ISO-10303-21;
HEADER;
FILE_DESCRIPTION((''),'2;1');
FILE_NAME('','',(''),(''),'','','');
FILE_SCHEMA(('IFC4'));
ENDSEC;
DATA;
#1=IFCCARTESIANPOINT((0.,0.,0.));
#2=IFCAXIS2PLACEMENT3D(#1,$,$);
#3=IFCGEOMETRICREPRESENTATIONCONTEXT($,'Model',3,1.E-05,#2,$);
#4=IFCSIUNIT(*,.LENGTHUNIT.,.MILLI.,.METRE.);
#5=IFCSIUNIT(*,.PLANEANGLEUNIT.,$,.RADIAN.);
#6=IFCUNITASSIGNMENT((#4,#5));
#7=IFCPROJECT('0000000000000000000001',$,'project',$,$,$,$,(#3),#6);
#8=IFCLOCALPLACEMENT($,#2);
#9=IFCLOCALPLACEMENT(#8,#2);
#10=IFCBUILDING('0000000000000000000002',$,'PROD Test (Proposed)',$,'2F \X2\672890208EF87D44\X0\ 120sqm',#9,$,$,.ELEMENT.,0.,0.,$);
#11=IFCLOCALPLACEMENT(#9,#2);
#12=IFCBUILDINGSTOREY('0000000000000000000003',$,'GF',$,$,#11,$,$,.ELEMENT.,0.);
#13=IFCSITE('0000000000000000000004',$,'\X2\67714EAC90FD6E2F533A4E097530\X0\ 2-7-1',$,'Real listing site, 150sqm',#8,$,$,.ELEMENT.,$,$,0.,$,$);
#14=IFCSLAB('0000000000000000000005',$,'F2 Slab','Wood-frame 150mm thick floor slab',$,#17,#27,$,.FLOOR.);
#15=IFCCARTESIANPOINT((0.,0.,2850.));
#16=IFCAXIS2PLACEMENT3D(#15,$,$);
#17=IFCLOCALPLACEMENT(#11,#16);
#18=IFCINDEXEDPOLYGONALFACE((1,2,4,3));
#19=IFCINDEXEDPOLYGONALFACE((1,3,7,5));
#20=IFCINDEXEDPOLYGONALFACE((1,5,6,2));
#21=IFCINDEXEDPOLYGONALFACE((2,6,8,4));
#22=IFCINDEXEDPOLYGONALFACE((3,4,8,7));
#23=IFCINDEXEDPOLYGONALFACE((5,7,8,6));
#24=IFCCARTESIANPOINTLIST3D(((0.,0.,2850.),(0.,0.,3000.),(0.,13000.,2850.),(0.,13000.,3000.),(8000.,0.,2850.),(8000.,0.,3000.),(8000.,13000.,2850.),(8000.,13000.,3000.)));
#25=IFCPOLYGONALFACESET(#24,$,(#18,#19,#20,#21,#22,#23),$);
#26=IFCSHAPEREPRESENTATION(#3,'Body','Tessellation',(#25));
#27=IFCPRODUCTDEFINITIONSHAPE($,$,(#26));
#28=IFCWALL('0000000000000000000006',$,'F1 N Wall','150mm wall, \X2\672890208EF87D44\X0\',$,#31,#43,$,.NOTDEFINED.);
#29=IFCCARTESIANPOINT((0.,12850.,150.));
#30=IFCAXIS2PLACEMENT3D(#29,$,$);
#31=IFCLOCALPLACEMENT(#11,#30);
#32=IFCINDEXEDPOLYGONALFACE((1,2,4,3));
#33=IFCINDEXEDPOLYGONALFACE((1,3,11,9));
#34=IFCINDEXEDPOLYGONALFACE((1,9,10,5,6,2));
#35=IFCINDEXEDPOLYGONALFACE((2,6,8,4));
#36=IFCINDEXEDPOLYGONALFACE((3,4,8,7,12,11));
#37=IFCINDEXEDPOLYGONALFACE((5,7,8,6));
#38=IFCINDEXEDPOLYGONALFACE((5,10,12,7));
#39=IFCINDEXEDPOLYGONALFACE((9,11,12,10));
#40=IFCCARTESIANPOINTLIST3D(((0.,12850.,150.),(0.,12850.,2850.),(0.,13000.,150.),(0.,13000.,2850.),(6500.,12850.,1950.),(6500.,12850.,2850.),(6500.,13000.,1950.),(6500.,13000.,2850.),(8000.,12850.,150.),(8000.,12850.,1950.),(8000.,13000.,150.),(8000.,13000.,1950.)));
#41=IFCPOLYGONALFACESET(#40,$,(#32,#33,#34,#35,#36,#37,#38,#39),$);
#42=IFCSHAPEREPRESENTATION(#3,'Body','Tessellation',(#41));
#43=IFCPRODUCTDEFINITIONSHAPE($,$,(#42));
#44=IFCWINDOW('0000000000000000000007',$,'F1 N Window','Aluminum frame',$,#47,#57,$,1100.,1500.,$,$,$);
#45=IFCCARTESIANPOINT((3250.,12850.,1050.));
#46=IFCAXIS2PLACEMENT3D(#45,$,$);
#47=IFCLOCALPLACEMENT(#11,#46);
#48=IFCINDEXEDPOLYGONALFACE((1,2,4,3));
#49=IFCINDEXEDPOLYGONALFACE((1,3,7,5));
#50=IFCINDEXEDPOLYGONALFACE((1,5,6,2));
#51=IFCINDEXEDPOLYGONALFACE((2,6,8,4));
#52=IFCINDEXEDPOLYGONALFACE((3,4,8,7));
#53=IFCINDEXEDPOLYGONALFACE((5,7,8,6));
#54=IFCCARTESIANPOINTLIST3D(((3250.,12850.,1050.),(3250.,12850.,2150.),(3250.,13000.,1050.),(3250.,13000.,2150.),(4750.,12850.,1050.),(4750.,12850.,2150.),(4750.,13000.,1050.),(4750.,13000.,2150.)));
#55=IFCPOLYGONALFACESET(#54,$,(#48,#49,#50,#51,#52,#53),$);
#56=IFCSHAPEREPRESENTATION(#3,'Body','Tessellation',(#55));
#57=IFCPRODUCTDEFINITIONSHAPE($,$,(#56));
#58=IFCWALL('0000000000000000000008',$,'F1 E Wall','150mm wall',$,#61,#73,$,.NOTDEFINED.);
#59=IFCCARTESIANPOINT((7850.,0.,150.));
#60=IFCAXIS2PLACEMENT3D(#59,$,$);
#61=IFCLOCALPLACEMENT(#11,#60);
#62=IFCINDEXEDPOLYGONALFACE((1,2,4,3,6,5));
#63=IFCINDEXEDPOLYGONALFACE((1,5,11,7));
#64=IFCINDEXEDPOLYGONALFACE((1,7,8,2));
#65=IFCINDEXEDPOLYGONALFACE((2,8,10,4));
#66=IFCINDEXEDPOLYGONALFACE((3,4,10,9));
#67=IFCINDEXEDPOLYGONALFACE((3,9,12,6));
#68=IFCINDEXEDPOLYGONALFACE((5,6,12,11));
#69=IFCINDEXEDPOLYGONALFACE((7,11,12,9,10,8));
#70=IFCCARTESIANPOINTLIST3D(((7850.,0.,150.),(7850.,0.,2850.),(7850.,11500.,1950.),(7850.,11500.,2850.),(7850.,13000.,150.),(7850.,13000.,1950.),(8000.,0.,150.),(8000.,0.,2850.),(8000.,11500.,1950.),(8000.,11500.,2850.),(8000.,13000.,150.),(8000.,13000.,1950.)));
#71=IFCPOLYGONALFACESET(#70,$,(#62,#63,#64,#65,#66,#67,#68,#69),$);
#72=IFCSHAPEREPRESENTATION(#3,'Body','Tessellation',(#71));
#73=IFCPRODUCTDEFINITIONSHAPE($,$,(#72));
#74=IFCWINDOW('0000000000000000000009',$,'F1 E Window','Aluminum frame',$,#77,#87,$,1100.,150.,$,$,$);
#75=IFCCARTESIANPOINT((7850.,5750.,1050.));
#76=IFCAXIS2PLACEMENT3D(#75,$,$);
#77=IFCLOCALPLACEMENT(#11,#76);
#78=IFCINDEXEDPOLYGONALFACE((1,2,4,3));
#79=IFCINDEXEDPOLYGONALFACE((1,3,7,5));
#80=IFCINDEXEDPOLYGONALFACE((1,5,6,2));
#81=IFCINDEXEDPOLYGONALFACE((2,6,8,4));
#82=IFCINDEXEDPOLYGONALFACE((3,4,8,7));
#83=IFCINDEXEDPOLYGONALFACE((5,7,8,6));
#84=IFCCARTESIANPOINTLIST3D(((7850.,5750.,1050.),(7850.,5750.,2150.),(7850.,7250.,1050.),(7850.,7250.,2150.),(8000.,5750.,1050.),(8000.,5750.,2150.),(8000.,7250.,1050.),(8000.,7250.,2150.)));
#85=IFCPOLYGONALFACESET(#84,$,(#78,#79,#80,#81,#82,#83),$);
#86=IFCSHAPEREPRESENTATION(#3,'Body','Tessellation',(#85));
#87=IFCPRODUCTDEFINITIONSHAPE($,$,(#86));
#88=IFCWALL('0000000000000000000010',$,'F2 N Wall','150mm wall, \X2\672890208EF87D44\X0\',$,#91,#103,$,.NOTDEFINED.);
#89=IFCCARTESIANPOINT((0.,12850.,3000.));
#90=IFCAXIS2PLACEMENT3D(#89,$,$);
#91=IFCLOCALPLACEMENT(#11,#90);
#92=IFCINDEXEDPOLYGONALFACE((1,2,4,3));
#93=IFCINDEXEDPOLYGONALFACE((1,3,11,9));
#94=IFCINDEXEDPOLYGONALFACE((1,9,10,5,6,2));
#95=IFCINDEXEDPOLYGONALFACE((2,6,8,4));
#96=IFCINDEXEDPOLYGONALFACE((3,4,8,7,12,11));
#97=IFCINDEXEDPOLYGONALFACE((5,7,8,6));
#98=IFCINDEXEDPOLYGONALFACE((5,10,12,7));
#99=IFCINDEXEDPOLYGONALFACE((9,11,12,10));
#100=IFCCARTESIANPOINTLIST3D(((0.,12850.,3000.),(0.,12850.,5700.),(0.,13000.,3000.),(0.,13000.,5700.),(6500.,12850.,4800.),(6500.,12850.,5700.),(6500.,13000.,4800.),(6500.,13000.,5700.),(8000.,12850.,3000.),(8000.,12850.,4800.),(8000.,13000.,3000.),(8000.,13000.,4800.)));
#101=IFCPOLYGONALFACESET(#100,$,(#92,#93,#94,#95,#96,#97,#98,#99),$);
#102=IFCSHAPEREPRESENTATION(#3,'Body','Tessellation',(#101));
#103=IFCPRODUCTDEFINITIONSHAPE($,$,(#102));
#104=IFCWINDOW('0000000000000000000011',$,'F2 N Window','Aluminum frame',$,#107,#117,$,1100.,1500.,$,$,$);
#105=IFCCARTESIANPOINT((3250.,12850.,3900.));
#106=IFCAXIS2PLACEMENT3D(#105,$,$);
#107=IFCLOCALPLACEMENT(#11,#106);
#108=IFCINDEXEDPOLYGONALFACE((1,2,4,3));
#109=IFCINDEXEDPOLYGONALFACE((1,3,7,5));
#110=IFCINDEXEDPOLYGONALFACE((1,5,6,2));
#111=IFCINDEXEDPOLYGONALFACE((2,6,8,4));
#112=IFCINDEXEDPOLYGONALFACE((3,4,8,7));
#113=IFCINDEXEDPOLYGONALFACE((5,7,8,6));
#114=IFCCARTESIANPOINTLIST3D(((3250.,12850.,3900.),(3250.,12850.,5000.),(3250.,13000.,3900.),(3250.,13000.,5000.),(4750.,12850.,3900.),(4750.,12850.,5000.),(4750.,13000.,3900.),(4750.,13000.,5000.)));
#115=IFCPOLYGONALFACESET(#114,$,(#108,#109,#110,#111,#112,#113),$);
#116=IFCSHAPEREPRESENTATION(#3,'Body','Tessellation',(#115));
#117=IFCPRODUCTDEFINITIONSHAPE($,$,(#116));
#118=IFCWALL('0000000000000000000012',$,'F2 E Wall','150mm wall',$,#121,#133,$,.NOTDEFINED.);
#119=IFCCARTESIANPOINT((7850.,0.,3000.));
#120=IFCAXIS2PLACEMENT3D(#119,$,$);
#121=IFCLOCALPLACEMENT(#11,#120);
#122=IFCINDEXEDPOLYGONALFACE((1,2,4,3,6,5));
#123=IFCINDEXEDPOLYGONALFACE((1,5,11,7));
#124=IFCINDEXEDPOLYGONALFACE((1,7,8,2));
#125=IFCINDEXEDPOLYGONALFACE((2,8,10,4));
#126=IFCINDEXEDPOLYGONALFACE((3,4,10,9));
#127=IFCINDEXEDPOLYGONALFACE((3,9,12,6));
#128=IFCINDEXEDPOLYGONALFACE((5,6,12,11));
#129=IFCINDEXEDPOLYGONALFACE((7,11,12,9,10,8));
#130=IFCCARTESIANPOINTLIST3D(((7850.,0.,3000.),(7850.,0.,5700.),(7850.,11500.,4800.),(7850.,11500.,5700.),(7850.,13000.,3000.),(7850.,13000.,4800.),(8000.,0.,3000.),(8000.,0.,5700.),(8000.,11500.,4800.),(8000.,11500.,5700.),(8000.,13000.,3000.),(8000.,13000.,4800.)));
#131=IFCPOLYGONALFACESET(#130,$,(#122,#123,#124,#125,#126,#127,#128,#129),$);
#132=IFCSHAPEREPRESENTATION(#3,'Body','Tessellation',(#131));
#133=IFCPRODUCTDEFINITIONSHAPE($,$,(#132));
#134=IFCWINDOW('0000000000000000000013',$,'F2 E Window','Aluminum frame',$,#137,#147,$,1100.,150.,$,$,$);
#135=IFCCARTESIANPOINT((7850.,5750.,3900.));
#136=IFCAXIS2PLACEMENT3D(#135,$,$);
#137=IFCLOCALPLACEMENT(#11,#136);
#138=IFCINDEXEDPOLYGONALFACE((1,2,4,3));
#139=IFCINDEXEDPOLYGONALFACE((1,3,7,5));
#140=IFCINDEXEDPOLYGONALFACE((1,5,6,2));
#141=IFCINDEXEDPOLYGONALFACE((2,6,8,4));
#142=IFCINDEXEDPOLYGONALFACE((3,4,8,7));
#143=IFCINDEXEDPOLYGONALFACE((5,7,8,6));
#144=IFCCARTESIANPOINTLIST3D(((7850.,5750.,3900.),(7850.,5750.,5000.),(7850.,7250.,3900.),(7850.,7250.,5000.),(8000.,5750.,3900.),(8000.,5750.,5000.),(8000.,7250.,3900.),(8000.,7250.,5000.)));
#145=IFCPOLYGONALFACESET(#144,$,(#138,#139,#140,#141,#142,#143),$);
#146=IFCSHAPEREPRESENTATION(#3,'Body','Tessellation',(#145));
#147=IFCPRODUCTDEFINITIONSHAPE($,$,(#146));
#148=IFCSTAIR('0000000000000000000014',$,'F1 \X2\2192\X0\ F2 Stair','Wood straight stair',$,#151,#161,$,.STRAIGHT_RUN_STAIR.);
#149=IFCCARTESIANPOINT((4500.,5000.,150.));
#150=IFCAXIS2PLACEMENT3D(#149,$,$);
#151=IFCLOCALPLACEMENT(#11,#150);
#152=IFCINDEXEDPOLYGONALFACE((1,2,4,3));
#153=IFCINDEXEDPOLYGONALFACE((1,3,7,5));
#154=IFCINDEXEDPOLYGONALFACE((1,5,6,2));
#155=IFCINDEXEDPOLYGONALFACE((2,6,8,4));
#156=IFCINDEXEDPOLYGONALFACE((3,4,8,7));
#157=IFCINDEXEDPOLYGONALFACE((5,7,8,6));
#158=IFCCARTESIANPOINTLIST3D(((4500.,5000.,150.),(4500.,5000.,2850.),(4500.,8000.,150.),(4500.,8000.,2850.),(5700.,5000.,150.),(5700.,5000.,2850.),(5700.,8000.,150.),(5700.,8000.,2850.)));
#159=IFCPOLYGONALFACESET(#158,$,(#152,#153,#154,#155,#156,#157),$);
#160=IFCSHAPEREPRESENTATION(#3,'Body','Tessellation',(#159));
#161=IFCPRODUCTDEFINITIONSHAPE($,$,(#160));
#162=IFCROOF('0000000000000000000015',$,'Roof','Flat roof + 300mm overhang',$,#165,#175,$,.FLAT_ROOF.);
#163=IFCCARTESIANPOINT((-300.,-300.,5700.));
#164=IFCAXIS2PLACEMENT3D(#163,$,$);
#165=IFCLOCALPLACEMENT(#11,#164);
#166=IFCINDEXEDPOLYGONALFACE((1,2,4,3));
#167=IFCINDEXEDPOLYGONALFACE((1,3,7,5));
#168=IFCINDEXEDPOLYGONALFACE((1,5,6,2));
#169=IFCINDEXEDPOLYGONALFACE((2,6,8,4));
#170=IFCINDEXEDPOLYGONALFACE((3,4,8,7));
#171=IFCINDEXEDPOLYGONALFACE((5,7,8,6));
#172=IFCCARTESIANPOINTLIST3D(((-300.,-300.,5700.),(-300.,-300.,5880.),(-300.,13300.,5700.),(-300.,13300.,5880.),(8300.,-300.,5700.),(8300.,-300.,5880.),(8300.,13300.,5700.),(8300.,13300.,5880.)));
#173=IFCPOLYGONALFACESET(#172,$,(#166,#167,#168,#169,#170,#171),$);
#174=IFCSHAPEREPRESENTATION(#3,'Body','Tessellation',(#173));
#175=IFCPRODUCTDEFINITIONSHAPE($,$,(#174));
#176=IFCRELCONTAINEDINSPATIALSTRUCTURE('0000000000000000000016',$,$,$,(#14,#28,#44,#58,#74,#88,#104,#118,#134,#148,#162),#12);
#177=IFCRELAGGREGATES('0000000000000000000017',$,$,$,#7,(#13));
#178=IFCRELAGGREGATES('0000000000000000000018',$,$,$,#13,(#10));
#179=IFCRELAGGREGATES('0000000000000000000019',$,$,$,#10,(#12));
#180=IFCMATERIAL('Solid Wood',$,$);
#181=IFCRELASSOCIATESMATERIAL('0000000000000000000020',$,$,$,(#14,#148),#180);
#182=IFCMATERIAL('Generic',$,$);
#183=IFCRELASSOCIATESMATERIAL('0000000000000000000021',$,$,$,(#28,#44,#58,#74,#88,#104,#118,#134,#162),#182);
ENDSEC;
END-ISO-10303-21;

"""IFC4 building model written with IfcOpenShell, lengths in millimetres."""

from ifc_helpers import new_model, si_unit, frame, frame_2d, origin, place, context, project, spatial, rectangle, extrude, material, element, fill, save


model = new_model("IFC4")

# Units and contexts
model_context = context("Model", 3, precision=1e-05, world=origin())
ifc_project = project(units=[si_unit("LENGTHUNIT", "METRE", prefix="MILLI"), si_unit("PLANEANGLEUNIT", "RADIAN")], contexts=[model_context])

# Site, building, storey
site_placement = place(None, origin())
site = spatial("IfcSite", under=ifc_project, at=site_placement, Name="東京都港区三田 2-7-1", ObjectType="Real listing site, 150sqm", CompositionType="ELEMENT", RefElevation=0.0)
building_placement = place(site_placement, origin())
building = spatial("IfcBuilding", under=site, at=building_placement, Name="PROD Test (Proposed)", ObjectType="2F 木造軸組 120sqm", CompositionType="ELEMENT", ElevationOfRefHeight=0.0, ElevationOfTerrain=0.0)
storey_placement = place(building_placement, origin())
storey = spatial("IfcBuildingStorey", under=building, at=storey_placement, Name="GF", CompositionType="ELEMENT", Elevation=0.0)

# Slab
ifc_material_1 = material(Name="Solid Wood")
slab_1_placement = place(storey_placement, frame((0.0, 0.0, 2850.0)))
element("IfcSlab", 1, at=slab_1_placement, inside=storey, material=ifc_material_1, Name="F2 Slab", Description="Wood-frame 150mm thick floor slab", PredefinedType="FLOOR", context=model_context, shape_type="SweptSolid", body=[
    extrude(rectangle(XDim=8000.0, YDim=13000.0, at=frame_2d((4000.0, 6500.0))), frame((0.0, 0.0, 2850.0)), (0.0, 0.0, 1.0), 150.0),
])

# Wall, opening, window
ifc_material_2 = material(Name="Generic")
wall_1_placement = place(storey_placement, frame((0.0, 12850.0, 150.0)))
wall_1 = element("IfcWall", 2, at=wall_1_placement, inside=storey, material=ifc_material_2, Name="F1 N Wall", Description="150mm wall, 木造軸組", PredefinedType="NOTDEFINED", context=model_context, shape_type="SweptSolid", body=[
    extrude(rectangle(XDim=8000.0, YDim=150.0, at=frame_2d((4000.0, 75.0))), frame((0.0, 12850.0, 150.0)), (0.0, 0.0, 1.0), 2700.0),
])
opening_1_placement = place(storey_placement, frame((3250.0, 12850.0, 1050.0)))
opening_1 = element("IfcOpeningElement", 3, at=opening_1_placement, cuts=wall_1, PredefinedType="NOTDEFINED", context=model_context, shape_type="SweptSolid", body=[
    extrude(rectangle(XDim=1500.0, YDim=150.0, at=frame_2d((750.0, 75.0))), frame((3250.0, 12850.0, 1050.0)), (0.0, 0.0, 1.0), 1100.0),
])
window_1_placement = place(storey_placement, frame((3250.0, 12850.0, 1050.0)))
window_1 = element("IfcWindow", 4, at=window_1_placement, inside=storey, material=ifc_material_2, Name="F1 N Window", Description="Aluminum frame", OverallHeight=1100.0, OverallWidth=1500.0, context=model_context, shape_type="SweptSolid", body=[
    extrude(rectangle(XDim=1500.0, YDim=150.0, at=frame_2d((750.0, 75.0))), frame((3250.0, 12850.0, 1050.0)), (0.0, 0.0, 1.0), 1100.0),
])
fill(opening_1, window_1)

# Walls, openings, windows
wall_2_placement = place(storey_placement, frame((7850.0, 0.0, 150.0)))
wall_2 = element("IfcWall", 5, at=wall_2_placement, inside=storey, material=ifc_material_2, Name="F1 E Wall", Description="150mm wall", PredefinedType="NOTDEFINED", context=model_context, shape_type="SweptSolid", body=[
    extrude(rectangle(XDim=150.0, YDim=13000.0, at=frame_2d((75.0, 6500.0))), frame((7850.0, 0.0, 150.0)), (0.0, 0.0, 1.0), 2700.0),
])
opening_2_placement = place(storey_placement, frame((7850.0, 5750.0, 1050.0)))
opening_2 = element("IfcOpeningElement", 6, at=opening_2_placement, cuts=wall_2, PredefinedType="NOTDEFINED", context=model_context, shape_type="SweptSolid", body=[
    extrude(rectangle(XDim=150.0, YDim=1500.0, at=frame_2d((75.0, 750.0))), frame((7850.0, 5750.0, 1050.0)), (0.0, 0.0, 1.0), 1100.0),
])
window_2_placement = place(storey_placement, frame((7850.0, 5750.0, 1050.0)))
window_2 = element("IfcWindow", 7, at=window_2_placement, inside=storey, material=ifc_material_2, Name="F1 E Window", Description="Aluminum frame", OverallHeight=1100.0, OverallWidth=150.0, context=model_context, shape_type="SweptSolid", body=[
    extrude(rectangle(XDim=150.0, YDim=1500.0, at=frame_2d((75.0, 750.0))), frame((7850.0, 5750.0, 1050.0)), (0.0, 0.0, 1.0), 1100.0),
])
fill(opening_2, window_2)
wall_3_placement = place(storey_placement, frame((0.0, 12850.0, 3000.0)))
wall_3 = element("IfcWall", 8, at=wall_3_placement, inside=storey, material=ifc_material_2, Name="F2 N Wall", Description="150mm wall, 木造軸組", PredefinedType="NOTDEFINED", context=model_context, shape_type="SweptSolid", body=[
    extrude(rectangle(XDim=8000.0, YDim=150.0, at=frame_2d((4000.0, 75.0))), frame((0.0, 12850.0, 3000.0)), (0.0, 0.0, 1.0), 2700.0),
])
opening_3_placement = place(storey_placement, frame((3250.0, 12850.0, 3900.0)))
opening_3 = element("IfcOpeningElement", 9, at=opening_3_placement, cuts=wall_3, PredefinedType="NOTDEFINED", context=model_context, shape_type="SweptSolid", body=[
    extrude(rectangle(XDim=1500.0, YDim=150.0, at=frame_2d((750.0, 75.0))), frame((3250.0, 12850.0, 3900.0)), (0.0, 0.0, 1.0), 1100.0),
])
window_3_placement = place(storey_placement, frame((3250.0, 12850.0, 3900.0)))
window_3 = element("IfcWindow", 10, at=window_3_placement, inside=storey, material=ifc_material_2, Name="F2 N Window", Description="Aluminum frame", OverallHeight=1100.0, OverallWidth=1500.0, context=model_context, shape_type="SweptSolid", body=[
    extrude(rectangle(XDim=1500.0, YDim=150.0, at=frame_2d((750.0, 75.0))), frame((3250.0, 12850.0, 3900.0)), (0.0, 0.0, 1.0), 1100.0),
])
fill(opening_3, window_3)
wall_4_placement = place(storey_placement, frame((7850.0, 0.0, 3000.0)))
wall_4 = element("IfcWall", 11, at=wall_4_placement, inside=storey, material=ifc_material_2, Name="F2 E Wall", Description="150mm wall", PredefinedType="NOTDEFINED", context=model_context, shape_type="SweptSolid", body=[
    extrude(rectangle(XDim=150.0, YDim=13000.0, at=frame_2d((75.0, 6500.0))), frame((7850.0, 0.0, 3000.0)), (0.0, 0.0, 1.0), 2700.0),
])
opening_4_placement = place(storey_placement, frame((7850.0, 5750.0, 3900.0)))
opening_4 = element("IfcOpeningElement", 12, at=opening_4_placement, cuts=wall_4, PredefinedType="NOTDEFINED", context=model_context, shape_type="SweptSolid", body=[
    extrude(rectangle(XDim=150.0, YDim=1500.0, at=frame_2d((75.0, 750.0))), frame((7850.0, 5750.0, 3900.0)), (0.0, 0.0, 1.0), 1100.0),
])
window_4_placement = place(storey_placement, frame((7850.0, 5750.0, 3900.0)))
window_4 = element("IfcWindow", 13, at=window_4_placement, inside=storey, material=ifc_material_2, Name="F2 E Window", Description="Aluminum frame", OverallHeight=1100.0, OverallWidth=150.0, context=model_context, shape_type="SweptSolid", body=[
    extrude(rectangle(XDim=150.0, YDim=1500.0, at=frame_2d((75.0, 750.0))), frame((7850.0, 5750.0, 3900.0)), (0.0, 0.0, 1.0), 1100.0),
])
fill(opening_4, window_4)

# Stair
stair_placement = place(storey_placement, frame((4500.0, 5000.0, 150.0)))
element("IfcStair", 14, at=stair_placement, inside=storey, material=ifc_material_1, Name="F1 → F2 Stair", Description="Wood straight stair", PredefinedType="STRAIGHT_RUN_STAIR", context=model_context, shape_type="SweptSolid", body=[
    extrude(rectangle(XDim=1200.0, YDim=3000.0, at=frame_2d((600.0, 1500.0))), frame((4500.0, 5000.0, 150.0)), (0.0, 0.0, 1.0), 2700.0),
])

# Roof
roof_placement = place(storey_placement, frame((-300.0, -300.0, 5700.0)))
element("IfcRoof", 15, at=roof_placement, inside=storey, material=ifc_material_2, Name="Roof", Description="Flat roof + 300mm overhang", PredefinedType="FLAT_ROOF", context=model_context, shape_type="SweptSolid", body=[
    extrude(rectangle(XDim=8600.0, YDim=13600.0, at=frame_2d((4300.0, 6800.0))), frame((-300.0, -300.0, 5700.0)), (0.0, 0.0, 1.0), 180.0),
])

save(model, "model.ifc")
